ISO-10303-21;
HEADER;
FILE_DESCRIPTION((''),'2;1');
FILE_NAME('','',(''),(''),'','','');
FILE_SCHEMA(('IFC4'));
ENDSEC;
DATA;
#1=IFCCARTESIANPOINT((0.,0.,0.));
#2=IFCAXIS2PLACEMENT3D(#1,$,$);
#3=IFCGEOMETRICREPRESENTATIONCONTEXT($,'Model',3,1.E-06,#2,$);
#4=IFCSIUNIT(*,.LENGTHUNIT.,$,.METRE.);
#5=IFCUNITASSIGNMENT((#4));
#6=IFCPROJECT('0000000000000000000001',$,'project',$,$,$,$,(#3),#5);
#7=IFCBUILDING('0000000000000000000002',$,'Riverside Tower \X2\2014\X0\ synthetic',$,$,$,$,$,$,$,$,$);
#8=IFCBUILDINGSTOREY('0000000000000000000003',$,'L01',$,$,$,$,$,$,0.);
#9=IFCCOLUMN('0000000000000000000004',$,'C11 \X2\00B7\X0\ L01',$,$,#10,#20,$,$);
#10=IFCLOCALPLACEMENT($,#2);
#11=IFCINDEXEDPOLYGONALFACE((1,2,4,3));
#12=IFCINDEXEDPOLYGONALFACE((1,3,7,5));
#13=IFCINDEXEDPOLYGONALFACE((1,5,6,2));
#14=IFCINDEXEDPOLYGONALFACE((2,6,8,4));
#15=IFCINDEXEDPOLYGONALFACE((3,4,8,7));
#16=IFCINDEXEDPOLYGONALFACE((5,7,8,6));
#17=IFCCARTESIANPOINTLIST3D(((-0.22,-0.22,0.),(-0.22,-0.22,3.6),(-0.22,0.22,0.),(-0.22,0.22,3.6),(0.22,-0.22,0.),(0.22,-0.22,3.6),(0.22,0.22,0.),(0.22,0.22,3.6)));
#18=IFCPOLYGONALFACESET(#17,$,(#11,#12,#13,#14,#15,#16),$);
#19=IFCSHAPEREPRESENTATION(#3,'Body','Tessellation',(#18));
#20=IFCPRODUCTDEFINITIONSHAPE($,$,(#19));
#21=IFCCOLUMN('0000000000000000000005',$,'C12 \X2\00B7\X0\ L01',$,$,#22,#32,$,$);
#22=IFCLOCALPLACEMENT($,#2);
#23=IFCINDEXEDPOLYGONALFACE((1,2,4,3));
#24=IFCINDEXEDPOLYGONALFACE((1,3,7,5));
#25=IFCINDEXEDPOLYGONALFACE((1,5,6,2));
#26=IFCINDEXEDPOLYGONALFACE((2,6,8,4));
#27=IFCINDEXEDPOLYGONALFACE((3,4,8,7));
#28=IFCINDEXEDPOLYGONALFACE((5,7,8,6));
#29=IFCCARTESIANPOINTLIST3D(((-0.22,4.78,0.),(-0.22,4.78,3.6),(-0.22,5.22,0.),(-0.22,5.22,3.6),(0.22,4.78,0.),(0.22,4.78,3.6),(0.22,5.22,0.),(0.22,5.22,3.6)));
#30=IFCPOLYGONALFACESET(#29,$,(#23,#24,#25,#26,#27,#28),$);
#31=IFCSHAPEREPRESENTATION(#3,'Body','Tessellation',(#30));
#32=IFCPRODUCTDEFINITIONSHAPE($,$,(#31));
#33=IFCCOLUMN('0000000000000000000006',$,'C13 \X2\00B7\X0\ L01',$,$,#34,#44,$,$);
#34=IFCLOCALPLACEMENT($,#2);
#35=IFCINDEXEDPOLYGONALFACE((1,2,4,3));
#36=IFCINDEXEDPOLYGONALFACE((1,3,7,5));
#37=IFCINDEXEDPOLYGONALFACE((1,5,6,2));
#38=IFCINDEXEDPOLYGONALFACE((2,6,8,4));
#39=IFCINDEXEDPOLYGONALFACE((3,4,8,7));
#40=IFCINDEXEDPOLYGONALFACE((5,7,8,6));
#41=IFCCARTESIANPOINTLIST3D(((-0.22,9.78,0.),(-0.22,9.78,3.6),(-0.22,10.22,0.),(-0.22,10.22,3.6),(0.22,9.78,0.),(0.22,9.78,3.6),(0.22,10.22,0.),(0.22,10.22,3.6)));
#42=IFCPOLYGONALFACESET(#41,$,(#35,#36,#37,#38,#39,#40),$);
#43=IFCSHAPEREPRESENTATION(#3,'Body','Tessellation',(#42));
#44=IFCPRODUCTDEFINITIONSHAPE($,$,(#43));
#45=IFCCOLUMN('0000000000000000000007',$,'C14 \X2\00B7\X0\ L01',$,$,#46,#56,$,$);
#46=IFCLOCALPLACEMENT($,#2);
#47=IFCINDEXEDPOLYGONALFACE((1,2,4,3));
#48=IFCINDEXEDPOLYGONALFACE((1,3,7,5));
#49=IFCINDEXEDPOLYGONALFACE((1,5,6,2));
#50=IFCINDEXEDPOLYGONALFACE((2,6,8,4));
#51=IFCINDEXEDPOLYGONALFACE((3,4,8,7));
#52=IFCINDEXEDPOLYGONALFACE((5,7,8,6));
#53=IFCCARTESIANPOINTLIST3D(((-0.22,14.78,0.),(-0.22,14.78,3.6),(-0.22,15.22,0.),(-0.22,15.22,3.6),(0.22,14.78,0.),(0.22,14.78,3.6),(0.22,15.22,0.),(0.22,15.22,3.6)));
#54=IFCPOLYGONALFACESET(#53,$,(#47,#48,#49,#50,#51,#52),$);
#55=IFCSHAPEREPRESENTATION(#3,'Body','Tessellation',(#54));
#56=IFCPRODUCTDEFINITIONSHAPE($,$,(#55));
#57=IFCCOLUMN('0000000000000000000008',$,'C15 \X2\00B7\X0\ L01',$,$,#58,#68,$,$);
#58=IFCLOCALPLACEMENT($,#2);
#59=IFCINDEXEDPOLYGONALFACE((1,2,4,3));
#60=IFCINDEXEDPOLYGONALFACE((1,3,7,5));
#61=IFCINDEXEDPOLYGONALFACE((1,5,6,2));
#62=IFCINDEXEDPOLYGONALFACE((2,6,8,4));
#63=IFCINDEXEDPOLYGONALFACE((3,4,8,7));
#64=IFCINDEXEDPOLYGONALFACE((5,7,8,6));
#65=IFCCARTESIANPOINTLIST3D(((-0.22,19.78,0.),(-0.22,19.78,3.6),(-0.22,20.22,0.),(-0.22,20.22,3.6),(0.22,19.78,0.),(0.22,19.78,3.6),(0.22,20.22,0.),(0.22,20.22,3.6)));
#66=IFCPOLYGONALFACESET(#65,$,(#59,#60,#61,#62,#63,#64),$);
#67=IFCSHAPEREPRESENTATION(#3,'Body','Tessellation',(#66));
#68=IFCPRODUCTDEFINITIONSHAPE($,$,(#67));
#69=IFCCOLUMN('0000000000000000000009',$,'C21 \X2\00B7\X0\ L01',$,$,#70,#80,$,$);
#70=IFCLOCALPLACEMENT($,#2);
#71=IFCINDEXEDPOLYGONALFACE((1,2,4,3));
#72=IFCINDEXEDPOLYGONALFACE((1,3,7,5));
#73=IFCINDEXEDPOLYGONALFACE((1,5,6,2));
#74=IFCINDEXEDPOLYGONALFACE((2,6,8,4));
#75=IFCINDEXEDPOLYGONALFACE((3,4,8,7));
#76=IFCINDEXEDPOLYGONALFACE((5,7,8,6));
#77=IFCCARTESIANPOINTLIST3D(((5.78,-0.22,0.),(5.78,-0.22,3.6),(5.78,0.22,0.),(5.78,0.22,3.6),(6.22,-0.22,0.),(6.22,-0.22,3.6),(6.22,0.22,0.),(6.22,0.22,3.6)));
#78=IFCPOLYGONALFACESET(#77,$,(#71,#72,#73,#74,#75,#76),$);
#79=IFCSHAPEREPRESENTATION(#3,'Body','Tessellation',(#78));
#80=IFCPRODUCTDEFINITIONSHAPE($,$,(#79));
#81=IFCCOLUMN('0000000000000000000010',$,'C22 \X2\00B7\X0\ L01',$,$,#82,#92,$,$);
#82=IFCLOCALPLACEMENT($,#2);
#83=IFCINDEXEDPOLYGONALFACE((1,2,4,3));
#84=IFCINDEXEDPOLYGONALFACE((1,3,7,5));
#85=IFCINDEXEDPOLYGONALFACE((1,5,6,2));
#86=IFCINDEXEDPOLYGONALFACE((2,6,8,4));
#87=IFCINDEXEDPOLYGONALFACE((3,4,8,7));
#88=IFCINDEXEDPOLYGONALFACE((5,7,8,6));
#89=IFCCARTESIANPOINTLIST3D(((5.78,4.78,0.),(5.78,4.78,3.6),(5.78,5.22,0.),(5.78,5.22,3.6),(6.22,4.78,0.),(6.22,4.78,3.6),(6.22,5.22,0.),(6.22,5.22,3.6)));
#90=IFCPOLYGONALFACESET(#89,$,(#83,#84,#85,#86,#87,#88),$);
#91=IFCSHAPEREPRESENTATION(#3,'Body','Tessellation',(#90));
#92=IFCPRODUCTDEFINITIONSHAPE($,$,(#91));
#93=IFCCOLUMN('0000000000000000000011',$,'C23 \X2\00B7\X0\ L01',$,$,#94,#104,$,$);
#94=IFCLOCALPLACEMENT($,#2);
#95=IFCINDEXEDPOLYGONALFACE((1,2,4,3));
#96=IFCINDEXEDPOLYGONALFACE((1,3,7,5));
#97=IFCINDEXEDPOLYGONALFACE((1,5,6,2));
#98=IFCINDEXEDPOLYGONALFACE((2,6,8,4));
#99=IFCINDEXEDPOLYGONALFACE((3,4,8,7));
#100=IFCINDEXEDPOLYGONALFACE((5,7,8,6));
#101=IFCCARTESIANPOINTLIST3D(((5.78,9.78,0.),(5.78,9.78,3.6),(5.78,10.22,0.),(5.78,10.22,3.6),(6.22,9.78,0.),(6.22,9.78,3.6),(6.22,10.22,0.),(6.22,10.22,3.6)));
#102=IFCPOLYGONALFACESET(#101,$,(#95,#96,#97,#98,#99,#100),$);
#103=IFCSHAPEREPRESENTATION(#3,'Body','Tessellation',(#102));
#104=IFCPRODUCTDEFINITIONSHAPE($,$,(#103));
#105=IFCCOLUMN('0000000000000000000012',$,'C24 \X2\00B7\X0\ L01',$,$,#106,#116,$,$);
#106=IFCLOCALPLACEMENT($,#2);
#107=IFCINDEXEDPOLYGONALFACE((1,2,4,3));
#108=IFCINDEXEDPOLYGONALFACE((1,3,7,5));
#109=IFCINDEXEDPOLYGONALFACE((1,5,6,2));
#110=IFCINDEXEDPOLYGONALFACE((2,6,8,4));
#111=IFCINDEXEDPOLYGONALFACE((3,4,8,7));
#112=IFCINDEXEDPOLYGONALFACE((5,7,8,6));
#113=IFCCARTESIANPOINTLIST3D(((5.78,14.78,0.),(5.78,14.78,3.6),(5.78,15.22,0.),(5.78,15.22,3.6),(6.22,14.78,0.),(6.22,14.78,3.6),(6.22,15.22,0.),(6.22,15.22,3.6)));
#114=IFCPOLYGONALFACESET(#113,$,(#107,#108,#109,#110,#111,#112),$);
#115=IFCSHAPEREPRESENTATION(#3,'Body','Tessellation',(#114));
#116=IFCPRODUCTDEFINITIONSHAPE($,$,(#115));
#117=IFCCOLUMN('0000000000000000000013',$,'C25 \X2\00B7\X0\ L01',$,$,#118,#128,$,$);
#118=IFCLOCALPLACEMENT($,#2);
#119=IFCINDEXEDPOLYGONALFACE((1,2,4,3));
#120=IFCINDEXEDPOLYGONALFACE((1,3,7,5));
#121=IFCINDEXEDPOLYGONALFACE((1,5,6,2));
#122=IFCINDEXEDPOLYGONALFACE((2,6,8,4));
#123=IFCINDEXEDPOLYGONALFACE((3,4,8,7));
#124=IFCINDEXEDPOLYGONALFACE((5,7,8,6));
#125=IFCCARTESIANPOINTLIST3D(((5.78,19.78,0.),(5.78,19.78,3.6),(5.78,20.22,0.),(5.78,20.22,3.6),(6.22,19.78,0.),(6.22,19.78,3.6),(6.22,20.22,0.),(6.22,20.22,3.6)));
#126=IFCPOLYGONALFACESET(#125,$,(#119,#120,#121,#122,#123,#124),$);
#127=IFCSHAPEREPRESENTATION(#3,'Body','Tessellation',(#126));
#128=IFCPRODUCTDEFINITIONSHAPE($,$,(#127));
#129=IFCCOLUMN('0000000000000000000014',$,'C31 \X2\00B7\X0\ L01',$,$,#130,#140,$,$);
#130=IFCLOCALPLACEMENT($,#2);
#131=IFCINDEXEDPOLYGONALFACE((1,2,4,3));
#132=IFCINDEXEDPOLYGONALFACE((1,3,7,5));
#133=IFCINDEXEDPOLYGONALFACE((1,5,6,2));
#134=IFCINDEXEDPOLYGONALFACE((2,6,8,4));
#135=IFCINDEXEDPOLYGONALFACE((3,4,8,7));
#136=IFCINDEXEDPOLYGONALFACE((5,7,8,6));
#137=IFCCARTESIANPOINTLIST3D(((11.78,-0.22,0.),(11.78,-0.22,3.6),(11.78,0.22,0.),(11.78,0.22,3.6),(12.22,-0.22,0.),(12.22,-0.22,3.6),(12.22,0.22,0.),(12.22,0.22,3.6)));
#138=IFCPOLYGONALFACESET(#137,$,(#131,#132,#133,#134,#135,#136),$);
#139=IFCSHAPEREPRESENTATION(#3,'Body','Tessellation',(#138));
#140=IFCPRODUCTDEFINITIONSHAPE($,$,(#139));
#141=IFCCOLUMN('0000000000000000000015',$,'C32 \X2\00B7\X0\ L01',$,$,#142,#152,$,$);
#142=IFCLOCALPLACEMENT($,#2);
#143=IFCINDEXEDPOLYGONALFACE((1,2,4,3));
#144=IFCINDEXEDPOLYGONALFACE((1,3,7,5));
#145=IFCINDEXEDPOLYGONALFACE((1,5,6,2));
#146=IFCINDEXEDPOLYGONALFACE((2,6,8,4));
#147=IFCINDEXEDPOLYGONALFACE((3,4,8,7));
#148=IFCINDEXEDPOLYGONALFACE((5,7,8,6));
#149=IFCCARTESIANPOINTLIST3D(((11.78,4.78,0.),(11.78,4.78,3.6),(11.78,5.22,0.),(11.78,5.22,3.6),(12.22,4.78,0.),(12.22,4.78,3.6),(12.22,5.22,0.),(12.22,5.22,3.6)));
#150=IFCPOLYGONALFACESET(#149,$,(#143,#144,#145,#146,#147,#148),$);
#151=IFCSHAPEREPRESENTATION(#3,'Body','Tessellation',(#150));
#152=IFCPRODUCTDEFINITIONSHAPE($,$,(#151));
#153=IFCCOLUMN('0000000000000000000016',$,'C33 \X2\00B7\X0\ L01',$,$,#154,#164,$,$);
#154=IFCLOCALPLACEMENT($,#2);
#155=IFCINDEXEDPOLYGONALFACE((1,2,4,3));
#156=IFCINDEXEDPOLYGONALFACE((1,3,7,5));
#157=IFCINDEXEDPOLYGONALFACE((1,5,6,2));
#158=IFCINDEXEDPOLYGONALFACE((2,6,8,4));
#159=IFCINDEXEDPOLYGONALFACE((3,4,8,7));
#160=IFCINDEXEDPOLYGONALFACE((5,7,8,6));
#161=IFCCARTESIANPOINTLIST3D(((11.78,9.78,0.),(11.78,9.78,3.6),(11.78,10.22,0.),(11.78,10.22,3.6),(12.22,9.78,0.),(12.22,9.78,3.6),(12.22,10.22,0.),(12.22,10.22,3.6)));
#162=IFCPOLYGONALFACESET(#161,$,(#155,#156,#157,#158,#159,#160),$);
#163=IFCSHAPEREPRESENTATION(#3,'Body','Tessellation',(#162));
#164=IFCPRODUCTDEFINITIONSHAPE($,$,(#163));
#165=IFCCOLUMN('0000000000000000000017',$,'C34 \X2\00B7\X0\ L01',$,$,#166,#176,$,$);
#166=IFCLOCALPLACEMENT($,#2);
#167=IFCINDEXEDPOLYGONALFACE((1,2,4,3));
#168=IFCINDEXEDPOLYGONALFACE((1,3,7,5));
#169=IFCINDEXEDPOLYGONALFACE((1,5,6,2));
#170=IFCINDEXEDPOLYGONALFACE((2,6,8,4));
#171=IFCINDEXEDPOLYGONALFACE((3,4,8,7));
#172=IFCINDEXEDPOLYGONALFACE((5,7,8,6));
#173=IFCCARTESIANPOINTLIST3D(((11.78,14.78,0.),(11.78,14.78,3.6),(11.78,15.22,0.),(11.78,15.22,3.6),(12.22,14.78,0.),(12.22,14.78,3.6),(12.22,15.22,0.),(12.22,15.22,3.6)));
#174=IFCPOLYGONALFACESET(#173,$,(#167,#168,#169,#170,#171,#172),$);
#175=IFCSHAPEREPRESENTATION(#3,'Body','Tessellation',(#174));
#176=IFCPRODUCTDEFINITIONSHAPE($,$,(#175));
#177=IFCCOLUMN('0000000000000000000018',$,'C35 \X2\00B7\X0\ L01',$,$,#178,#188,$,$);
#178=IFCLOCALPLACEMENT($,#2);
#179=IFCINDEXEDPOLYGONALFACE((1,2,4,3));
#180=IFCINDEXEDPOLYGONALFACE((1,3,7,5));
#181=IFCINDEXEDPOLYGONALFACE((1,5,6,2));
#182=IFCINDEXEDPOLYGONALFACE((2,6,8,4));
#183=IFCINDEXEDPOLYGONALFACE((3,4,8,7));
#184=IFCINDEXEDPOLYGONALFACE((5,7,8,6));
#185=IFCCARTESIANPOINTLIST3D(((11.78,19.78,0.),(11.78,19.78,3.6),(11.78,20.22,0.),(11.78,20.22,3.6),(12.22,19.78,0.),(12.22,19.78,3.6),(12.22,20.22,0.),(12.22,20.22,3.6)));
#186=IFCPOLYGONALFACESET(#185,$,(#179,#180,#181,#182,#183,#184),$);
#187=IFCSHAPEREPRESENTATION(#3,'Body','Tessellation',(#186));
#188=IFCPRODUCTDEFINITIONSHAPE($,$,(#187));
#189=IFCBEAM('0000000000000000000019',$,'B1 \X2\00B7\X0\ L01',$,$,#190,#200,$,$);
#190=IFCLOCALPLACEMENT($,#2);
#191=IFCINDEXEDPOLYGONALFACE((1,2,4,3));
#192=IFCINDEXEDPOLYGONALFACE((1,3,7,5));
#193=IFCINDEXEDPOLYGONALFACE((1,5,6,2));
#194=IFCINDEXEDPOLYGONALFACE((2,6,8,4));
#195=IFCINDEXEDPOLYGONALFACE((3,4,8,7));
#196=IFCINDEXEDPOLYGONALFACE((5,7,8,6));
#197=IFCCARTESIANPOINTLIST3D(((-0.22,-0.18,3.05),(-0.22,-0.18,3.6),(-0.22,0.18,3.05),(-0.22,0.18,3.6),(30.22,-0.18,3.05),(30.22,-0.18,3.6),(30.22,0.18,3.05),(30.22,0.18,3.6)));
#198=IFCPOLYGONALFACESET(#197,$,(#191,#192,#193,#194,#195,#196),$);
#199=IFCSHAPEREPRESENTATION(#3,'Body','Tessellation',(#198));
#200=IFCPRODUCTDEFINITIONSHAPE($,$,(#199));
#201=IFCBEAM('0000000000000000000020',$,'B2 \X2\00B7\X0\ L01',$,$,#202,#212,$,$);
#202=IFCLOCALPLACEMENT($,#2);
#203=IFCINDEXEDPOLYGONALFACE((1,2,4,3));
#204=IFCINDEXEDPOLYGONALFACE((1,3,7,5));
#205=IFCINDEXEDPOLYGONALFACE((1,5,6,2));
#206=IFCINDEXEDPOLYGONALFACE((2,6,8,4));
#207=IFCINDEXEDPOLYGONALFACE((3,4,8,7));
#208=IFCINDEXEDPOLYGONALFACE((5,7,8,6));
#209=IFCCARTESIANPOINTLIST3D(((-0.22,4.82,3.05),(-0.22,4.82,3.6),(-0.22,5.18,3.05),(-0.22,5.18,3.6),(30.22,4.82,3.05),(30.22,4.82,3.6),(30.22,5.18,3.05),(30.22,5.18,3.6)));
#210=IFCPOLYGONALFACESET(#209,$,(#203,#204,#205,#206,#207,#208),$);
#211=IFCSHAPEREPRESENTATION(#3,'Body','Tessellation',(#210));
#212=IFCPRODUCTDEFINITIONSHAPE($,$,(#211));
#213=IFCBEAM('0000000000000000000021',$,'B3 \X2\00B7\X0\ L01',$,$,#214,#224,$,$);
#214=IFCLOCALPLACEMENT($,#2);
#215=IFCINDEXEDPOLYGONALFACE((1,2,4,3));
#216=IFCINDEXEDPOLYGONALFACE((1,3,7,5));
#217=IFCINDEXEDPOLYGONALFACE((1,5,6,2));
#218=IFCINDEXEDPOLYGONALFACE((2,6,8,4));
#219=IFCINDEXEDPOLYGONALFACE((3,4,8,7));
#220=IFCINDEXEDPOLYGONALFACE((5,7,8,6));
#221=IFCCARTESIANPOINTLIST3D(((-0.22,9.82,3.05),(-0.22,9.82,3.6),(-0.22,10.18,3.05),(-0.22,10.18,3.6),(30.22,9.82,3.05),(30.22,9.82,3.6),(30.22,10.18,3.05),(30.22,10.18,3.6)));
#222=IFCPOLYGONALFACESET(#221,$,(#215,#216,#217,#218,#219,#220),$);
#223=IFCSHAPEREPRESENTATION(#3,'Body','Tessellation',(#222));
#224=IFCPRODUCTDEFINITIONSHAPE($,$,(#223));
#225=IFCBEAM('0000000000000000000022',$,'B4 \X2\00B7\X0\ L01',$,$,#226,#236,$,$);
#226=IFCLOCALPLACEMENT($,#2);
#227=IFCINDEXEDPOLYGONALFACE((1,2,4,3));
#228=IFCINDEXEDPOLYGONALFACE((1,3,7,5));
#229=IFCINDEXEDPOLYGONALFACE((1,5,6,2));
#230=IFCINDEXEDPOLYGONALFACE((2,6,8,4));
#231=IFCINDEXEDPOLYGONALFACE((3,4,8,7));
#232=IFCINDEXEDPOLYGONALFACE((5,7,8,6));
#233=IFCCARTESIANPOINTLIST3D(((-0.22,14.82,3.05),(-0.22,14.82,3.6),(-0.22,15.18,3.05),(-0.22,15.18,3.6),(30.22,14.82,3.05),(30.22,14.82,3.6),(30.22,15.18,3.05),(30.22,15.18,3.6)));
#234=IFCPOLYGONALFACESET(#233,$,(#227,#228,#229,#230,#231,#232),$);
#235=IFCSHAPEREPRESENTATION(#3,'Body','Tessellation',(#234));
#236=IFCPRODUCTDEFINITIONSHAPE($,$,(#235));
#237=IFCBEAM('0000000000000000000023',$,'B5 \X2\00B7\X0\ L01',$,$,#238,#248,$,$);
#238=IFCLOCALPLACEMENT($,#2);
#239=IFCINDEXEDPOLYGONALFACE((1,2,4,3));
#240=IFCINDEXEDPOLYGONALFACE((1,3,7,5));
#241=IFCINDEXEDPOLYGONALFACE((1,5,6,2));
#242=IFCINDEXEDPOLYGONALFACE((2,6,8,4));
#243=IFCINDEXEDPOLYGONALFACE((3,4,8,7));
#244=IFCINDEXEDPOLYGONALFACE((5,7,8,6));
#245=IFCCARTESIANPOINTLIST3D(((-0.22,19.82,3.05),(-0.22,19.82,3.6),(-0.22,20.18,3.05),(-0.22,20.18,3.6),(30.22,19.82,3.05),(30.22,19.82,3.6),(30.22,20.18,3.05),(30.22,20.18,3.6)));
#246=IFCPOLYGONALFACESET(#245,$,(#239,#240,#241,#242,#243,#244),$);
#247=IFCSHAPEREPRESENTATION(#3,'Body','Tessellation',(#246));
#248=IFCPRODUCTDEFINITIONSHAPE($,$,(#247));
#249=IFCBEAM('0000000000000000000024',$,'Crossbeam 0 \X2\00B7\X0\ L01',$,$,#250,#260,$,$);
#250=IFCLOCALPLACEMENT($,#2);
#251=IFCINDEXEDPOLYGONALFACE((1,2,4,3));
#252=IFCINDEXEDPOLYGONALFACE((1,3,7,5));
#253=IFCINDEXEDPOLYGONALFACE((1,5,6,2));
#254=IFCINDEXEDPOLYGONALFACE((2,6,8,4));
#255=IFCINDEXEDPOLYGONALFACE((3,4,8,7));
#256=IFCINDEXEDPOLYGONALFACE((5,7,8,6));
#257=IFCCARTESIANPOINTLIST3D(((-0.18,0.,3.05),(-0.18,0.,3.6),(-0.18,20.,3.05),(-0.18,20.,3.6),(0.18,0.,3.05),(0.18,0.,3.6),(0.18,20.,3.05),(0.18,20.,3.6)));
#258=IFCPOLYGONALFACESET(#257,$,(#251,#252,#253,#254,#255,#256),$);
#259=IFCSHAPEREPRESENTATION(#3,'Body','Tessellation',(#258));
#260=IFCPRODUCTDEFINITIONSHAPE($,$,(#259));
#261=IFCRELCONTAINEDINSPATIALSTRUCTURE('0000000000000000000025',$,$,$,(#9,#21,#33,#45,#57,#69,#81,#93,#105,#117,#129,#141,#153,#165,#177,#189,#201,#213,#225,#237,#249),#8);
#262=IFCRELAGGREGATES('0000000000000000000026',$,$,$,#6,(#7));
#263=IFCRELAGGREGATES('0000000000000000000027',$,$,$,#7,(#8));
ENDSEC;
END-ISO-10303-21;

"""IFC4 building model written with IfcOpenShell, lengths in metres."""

from ifc_helpers import new_model, si_unit, frame, origin, place, context, project, spatial, rectangle, extrude, element, save


model = new_model("IFC4")

# Units and contexts
model_context = context("Model", 3, precision=1e-06, world=origin())
ifc_project = project(units=[si_unit("LENGTHUNIT", "METRE")], contexts=[model_context])

# Building, storey
building = spatial("IfcBuilding", under=ifc_project, Name="Riverside Tower — synthetic")
storey = spatial("IfcBuildingStorey", under=building, Name="L01", Elevation=0.0)

# Columns
for number, where, name in (
    (1, (0.0, 0.0, 0.0), "C11 · L01"),
    (2, (0.0, 5.0, 0.0), "C12 · L01"),
    (3, (0.0, 10.0, 0.0), "C13 · L01"),
    (4, (0.0, 15.0, 0.0), "C14 · L01"),
    (5, (0.0, 20.0, 0.0), "C15 · L01"),
    (6, (6.0, 0.0, 0.0), "C21 · L01"),
    (7, (6.0, 5.0, 0.0), "C22 · L01"),
    (8, (6.0, 10.0, 0.0), "C23 · L01"),
    (9, (6.0, 15.0, 0.0), "C24 · L01"),
    (10, (6.0, 20.0, 0.0), "C25 · L01"),
    (11, (12.0, 0.0, 0.0), "C31 · L01"),
    (12, (12.0, 5.0, 0.0), "C32 · L01"),
    (13, (12.0, 10.0, 0.0), "C33 · L01"),
    (14, (12.0, 15.0, 0.0), "C34 · L01"),
    (15, (12.0, 20.0, 0.0), "C35 · L01"),
):
    element("IfcColumn", number, at=place(None, frame(where)), inside=storey, Name=name, context=model_context, shape_type="SweptSolid", body=[
        extrude(rectangle(XDim=0.44, YDim=0.44), origin(), (0.0, 0.0, 1.0), 3.6),
    ])

# Beams
for number, where, name in (
    (16, (15.0, 0.0, 3.05), "B1 · L01"),
    (17, (15.0, 5.0, 3.05), "B2 · L01"),
    (18, (15.0, 10.0, 3.05), "B3 · L01"),
    (19, (15.0, 15.0, 3.05), "B4 · L01"),
    (20, (15.0, 20.0, 3.05), "B5 · L01"),
):
    element("IfcBeam", number, at=place(None, frame(where)), inside=storey, Name=name, context=model_context, shape_type="SweptSolid", body=[
        extrude(rectangle(XDim=30.44, YDim=0.36), origin(), (0.0, 0.0, 1.0), 0.55),
    ])
for number, where, name in (
    (21, (0.0, 10.0, 3.05), "Crossbeam 0 · L01"),
):
    element("IfcBeam", number, at=place(None, frame(where)), inside=storey, Name=name, context=model_context, shape_type="SweptSolid", body=[
        extrude(rectangle(XDim=0.36, YDim=20.0), origin(), (0.0, 0.0, 1.0), 0.55),
    ])

save(model, "model.ifc")
